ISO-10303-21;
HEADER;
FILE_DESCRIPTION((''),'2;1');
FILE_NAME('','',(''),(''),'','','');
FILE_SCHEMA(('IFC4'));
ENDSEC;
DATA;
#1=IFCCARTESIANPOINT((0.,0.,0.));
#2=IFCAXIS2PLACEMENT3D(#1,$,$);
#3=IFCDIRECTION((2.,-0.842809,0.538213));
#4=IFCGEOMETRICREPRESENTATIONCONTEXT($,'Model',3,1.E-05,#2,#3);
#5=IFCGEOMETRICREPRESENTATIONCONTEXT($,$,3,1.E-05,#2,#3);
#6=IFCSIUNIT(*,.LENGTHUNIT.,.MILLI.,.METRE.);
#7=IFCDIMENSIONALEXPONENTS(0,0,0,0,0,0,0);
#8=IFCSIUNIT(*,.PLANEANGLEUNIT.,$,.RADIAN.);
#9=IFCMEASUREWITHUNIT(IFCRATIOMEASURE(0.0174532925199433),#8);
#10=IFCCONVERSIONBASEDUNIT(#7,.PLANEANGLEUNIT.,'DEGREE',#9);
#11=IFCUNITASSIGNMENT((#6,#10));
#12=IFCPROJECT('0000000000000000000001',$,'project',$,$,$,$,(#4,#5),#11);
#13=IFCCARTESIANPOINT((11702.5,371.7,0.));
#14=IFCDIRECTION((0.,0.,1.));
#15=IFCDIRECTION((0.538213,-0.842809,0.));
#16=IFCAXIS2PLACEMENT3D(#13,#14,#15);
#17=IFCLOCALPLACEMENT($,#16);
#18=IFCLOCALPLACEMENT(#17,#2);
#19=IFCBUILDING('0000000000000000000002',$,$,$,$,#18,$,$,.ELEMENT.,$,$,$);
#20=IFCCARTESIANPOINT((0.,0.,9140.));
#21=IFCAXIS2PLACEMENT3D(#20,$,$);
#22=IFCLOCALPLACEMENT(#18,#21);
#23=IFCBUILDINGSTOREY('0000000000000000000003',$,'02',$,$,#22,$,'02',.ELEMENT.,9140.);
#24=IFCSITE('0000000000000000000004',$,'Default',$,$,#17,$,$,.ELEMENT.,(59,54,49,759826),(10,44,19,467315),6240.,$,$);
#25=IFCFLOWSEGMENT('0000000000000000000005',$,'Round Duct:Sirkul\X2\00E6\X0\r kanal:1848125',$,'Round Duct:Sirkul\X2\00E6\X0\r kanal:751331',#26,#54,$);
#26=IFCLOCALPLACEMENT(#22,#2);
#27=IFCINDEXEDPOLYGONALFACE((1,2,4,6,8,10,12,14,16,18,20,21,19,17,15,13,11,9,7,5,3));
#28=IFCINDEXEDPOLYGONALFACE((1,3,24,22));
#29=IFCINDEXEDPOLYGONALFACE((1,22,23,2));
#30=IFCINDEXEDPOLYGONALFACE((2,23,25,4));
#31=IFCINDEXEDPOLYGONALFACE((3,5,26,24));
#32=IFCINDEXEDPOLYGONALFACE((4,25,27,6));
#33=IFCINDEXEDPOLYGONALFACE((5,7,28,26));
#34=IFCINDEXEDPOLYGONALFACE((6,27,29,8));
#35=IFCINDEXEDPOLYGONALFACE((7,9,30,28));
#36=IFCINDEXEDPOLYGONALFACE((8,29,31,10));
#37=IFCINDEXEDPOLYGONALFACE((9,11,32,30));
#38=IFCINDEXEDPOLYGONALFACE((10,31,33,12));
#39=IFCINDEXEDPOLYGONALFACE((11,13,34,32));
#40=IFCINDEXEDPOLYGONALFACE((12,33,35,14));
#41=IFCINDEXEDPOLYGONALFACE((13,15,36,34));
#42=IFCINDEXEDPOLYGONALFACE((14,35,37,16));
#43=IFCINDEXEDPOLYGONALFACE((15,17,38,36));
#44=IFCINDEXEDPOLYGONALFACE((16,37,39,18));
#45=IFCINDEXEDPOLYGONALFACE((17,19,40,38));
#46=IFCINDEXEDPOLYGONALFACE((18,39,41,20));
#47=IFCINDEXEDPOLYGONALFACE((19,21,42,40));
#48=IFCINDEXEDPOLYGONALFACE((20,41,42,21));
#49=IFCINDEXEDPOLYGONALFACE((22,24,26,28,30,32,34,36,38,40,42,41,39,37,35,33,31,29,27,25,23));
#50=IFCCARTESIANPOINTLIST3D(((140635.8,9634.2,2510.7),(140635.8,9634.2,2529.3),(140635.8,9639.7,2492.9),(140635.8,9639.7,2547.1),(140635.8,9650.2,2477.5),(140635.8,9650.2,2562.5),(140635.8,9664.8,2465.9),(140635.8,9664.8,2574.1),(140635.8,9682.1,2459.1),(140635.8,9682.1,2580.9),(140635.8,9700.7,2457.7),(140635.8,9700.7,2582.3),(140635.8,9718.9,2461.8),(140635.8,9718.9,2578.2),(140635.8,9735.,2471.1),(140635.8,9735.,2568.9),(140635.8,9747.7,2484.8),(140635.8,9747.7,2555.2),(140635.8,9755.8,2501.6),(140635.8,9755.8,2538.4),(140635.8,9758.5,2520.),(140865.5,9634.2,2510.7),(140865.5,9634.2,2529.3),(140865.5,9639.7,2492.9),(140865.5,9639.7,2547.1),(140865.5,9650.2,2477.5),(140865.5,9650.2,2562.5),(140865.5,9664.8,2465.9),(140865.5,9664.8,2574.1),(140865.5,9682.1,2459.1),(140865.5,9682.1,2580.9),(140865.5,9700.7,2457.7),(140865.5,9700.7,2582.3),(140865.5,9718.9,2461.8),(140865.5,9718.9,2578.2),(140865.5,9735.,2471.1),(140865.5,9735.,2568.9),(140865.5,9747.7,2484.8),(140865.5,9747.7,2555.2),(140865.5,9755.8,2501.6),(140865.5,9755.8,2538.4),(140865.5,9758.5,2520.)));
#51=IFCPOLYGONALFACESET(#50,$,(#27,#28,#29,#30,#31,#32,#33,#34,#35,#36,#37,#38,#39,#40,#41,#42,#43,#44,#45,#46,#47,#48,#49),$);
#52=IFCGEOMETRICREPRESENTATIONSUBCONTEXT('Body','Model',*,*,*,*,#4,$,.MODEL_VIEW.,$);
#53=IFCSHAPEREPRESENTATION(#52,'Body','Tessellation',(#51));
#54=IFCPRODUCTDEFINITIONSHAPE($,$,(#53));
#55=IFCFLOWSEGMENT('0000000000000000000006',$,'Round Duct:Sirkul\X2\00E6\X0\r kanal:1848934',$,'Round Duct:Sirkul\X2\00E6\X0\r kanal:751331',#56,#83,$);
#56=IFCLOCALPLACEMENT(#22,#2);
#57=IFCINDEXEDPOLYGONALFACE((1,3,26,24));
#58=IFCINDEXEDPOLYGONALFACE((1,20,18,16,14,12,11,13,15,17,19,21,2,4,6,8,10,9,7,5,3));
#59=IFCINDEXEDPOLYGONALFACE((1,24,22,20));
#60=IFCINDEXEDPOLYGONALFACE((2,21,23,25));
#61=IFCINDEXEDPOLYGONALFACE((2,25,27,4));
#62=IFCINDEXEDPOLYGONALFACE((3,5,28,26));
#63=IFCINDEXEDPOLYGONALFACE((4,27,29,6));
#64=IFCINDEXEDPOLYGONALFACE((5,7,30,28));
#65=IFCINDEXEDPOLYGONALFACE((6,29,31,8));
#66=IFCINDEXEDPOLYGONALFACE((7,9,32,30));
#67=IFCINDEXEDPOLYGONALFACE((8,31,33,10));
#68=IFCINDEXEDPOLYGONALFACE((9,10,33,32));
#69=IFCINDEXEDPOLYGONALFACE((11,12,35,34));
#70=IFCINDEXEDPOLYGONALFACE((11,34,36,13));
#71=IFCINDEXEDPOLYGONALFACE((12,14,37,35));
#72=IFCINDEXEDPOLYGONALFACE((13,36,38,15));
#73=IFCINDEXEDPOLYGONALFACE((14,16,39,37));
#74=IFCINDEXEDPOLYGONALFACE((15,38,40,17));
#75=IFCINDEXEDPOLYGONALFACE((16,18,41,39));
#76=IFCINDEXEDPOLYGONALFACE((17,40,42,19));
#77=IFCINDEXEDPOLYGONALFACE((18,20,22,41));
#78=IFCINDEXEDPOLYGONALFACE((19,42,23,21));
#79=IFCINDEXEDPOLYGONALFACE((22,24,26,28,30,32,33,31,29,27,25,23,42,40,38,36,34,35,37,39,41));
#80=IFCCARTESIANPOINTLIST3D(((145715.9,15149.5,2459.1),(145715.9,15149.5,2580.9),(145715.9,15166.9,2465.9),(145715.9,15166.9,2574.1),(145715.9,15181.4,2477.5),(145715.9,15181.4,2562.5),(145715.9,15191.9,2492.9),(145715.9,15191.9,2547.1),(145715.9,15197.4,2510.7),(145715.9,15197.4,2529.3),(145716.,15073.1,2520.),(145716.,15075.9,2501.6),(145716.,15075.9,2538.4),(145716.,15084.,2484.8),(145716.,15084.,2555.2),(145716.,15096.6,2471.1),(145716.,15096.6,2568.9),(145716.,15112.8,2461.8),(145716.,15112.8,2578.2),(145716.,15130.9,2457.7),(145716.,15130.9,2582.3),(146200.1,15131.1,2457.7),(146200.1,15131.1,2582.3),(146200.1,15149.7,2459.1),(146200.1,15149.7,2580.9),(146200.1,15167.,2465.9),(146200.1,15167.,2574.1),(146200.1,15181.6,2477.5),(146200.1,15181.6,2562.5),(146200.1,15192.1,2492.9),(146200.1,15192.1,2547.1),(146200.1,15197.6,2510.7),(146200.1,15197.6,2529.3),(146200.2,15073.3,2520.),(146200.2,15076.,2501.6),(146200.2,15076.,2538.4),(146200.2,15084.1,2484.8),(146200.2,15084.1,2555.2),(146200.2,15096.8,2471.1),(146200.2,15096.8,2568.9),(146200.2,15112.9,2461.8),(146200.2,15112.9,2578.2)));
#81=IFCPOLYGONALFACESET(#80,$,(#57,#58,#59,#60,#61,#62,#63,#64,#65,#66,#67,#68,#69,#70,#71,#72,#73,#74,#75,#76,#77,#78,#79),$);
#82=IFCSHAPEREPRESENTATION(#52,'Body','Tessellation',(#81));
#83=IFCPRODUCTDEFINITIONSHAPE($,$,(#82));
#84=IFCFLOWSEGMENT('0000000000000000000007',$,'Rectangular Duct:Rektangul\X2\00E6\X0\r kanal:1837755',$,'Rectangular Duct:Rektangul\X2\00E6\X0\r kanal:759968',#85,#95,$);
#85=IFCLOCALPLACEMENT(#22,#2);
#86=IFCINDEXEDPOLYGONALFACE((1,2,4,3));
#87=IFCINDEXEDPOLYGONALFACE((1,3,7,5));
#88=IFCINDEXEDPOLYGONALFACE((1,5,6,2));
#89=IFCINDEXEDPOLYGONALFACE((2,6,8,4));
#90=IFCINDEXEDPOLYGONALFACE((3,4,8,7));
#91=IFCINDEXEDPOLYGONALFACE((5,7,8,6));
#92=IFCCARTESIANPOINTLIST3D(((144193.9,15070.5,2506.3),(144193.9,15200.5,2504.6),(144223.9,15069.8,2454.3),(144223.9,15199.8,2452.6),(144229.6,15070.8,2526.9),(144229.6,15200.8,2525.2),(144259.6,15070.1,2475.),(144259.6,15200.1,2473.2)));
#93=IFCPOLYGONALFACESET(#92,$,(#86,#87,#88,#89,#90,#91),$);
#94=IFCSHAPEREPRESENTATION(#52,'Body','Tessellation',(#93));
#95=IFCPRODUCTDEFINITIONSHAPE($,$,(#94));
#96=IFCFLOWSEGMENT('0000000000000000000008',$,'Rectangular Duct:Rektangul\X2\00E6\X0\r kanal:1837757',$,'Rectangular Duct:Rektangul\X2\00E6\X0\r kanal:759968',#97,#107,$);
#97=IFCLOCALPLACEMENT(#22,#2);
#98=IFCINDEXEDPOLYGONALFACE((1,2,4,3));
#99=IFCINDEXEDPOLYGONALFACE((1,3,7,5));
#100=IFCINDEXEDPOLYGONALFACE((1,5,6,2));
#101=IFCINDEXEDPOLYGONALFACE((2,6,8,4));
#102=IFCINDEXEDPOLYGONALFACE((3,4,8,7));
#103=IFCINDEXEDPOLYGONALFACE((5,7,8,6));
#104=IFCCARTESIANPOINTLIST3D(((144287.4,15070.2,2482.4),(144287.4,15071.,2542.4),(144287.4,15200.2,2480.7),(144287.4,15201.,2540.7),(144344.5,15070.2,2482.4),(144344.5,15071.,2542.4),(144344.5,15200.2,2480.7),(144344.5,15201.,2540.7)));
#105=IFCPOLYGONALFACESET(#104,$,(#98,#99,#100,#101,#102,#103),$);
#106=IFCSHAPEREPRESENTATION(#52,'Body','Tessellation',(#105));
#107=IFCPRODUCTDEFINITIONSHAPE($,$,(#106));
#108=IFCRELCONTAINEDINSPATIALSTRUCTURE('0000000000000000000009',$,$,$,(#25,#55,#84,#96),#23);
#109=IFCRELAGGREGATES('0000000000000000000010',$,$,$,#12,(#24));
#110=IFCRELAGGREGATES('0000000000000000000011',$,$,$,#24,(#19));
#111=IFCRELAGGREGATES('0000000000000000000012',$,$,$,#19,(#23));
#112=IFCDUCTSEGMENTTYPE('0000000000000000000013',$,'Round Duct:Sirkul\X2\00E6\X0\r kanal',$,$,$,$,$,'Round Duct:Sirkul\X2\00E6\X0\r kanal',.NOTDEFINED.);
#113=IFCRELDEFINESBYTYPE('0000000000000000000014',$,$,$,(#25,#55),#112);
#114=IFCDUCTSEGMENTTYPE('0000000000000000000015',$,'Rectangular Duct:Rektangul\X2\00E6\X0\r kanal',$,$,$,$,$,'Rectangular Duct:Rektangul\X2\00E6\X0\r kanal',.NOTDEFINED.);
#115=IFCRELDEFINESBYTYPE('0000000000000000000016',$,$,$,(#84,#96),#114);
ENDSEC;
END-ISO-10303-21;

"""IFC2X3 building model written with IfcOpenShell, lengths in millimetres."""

from ifc_helpers import new_model, entity, si_unit, converted_unit, direction, frame, frame_2d, origin, origin_2d_with_axis, place, context, subcontext, project, spatial, rectangle, circle, extrude, type_object, element, save


model = new_model("IFC2X3")

# Units and contexts
model_context = context("Model", 3, precision=1e-05, world=origin(), true_north=direction((2.0, -0.842809, 0.538213)))
context_of_model = context(None, 3, precision=1e-05, world=origin(), true_north=direction((2.0, -0.842809, 0.538213)))
body_context = subcontext(model_context, "Body", "Model", "MODEL_VIEW")
ifc_project = project(units=[si_unit("LENGTHUNIT", "METRE", prefix="MILLI"), converted_unit("PLANEANGLEUNIT", "DEGREE", entity("IfcRatioMeasure", 0.0174532925199433), si_unit("PLANEANGLEUNIT", "RADIAN"), dimensions=[0, 0, 0, 0, 0, 0, 0])], contexts=[model_context, context_of_model])

# Site, building, storey
site_placement = place(None, frame((11702.5, 371.7, 0.0), z_axis=(0.0, 0.0, 1.0), x_axis=(0.538213, -0.842809, 0.0)))
site = spatial("IfcSite", under=ifc_project, at=site_placement, Name="Default", CompositionType="ELEMENT", RefLatitude=(59, 54, 49, 759826), RefLongitude=(10, 44, 19, 467315), RefElevation=6240.0)
building_placement = place(site_placement, origin())
building = spatial("IfcBuilding", under=site, at=building_placement, CompositionType="ELEMENT")
storey_placement = place(building_placement, frame((0.0, 0.0, 9140.0)))
storey = spatial("IfcBuildingStorey", under=building, at=storey_placement, Name="02", LongName="02", CompositionType="ELEMENT", Elevation=9140.0)

# Flow segments
duct_segment_type_1 = type_object("IfcDuctSegmentType", Name="Round Duct:Sirkulær kanal", ElementType="Round Duct:Sirkulær kanal", PredefinedType="NOTDEFINED")
flow_segment_1_placement = place(storey_placement, origin())
element("IfcFlowSegment", 1, at=flow_segment_1_placement, inside=storey, type_object=duct_segment_type_1, Name="Round Duct:Sirkulær kanal:1848125", ObjectType="Round Duct:Sirkulær kanal:751331", context=body_context, shape_type="SweptSolid", body=[
    extrude(circle(Radius=62.5, at=frame_2d((0.0, 0.0), x_axis=(1.0, 0.0))), frame((140635.8, 9696.0, 2520.0), z_axis=(1.0, 0.0, 0.0), x_axis=(0.0, 1.0, 0.0)), (0.0, 0.0, 1.0), 229.7),
])
flow_segment_2_placement = place(storey_placement, origin())
element("IfcFlowSegment", 2, at=flow_segment_2_placement, inside=storey, type_object=duct_segment_type_1, Name="Round Duct:Sirkulær kanal:1848934", ObjectType="Round Duct:Sirkulær kanal:751331", context=body_context, shape_type="SweptSolid", body=[
    extrude(circle(Radius=62.5, at=origin_2d_with_axis()), frame((145716.0, 15135.6, 2520.0), z_axis=(1.0, 0.000337, 0.0), x_axis=(0.000337, -1.0, 0.0)), (0.0, 0.0, 1.0), 484.2),
])
duct_segment_type_2 = type_object("IfcDuctSegmentType", Name="Rectangular Duct:Rektangulær kanal", ElementType="Rectangular Duct:Rektangulær kanal", PredefinedType="NOTDEFINED")
flow_segment_3_placement = place(storey_placement, origin())
element("IfcFlowSegment", 3, at=flow_segment_3_placement, inside=storey, type_object=duct_segment_type_2, Name="Rectangular Duct:Rektangulær kanal:1837755", ObjectType="Rectangular Duct:Rektangulær kanal:759968", context=body_context, shape_type="SweptSolid", body=[
    extrude(rectangle(XDim=60.0, YDim=41.2, at=frame_2d((0.0, 0.0), x_axis=(0.0, 1.0))), frame((144226.8, 15070.3, 2490.6), z_axis=(0.0, 0.999912, -0.013237), x_axis=(0.866, 0.006619, 0.5)), (0.0, 0.0, 1.0), 130.0),
])
flow_segment_4_placement = place(storey_placement, origin())
element("IfcFlowSegment", 4, at=flow_segment_4_placement, inside=storey, type_object=duct_segment_type_2, Name="Rectangular Duct:Rektangulær kanal:1837757", ObjectType="Rectangular Duct:Rektangulær kanal:759968", context=body_context, shape_type="SweptSolid", body=[
    extrude(rectangle(XDim=60.0, YDim=57.1, at=frame_2d((0.0, 0.0), x_axis=(0.0, 1.0))), frame((144316.0, 15070.6, 2512.4), z_axis=(0.0, 0.999912, -0.013237), x_axis=(1.0, 0.0, 0.0)), (0.0, 0.0, 1.0), 130.0),
])

save(model, "model.ifc")
